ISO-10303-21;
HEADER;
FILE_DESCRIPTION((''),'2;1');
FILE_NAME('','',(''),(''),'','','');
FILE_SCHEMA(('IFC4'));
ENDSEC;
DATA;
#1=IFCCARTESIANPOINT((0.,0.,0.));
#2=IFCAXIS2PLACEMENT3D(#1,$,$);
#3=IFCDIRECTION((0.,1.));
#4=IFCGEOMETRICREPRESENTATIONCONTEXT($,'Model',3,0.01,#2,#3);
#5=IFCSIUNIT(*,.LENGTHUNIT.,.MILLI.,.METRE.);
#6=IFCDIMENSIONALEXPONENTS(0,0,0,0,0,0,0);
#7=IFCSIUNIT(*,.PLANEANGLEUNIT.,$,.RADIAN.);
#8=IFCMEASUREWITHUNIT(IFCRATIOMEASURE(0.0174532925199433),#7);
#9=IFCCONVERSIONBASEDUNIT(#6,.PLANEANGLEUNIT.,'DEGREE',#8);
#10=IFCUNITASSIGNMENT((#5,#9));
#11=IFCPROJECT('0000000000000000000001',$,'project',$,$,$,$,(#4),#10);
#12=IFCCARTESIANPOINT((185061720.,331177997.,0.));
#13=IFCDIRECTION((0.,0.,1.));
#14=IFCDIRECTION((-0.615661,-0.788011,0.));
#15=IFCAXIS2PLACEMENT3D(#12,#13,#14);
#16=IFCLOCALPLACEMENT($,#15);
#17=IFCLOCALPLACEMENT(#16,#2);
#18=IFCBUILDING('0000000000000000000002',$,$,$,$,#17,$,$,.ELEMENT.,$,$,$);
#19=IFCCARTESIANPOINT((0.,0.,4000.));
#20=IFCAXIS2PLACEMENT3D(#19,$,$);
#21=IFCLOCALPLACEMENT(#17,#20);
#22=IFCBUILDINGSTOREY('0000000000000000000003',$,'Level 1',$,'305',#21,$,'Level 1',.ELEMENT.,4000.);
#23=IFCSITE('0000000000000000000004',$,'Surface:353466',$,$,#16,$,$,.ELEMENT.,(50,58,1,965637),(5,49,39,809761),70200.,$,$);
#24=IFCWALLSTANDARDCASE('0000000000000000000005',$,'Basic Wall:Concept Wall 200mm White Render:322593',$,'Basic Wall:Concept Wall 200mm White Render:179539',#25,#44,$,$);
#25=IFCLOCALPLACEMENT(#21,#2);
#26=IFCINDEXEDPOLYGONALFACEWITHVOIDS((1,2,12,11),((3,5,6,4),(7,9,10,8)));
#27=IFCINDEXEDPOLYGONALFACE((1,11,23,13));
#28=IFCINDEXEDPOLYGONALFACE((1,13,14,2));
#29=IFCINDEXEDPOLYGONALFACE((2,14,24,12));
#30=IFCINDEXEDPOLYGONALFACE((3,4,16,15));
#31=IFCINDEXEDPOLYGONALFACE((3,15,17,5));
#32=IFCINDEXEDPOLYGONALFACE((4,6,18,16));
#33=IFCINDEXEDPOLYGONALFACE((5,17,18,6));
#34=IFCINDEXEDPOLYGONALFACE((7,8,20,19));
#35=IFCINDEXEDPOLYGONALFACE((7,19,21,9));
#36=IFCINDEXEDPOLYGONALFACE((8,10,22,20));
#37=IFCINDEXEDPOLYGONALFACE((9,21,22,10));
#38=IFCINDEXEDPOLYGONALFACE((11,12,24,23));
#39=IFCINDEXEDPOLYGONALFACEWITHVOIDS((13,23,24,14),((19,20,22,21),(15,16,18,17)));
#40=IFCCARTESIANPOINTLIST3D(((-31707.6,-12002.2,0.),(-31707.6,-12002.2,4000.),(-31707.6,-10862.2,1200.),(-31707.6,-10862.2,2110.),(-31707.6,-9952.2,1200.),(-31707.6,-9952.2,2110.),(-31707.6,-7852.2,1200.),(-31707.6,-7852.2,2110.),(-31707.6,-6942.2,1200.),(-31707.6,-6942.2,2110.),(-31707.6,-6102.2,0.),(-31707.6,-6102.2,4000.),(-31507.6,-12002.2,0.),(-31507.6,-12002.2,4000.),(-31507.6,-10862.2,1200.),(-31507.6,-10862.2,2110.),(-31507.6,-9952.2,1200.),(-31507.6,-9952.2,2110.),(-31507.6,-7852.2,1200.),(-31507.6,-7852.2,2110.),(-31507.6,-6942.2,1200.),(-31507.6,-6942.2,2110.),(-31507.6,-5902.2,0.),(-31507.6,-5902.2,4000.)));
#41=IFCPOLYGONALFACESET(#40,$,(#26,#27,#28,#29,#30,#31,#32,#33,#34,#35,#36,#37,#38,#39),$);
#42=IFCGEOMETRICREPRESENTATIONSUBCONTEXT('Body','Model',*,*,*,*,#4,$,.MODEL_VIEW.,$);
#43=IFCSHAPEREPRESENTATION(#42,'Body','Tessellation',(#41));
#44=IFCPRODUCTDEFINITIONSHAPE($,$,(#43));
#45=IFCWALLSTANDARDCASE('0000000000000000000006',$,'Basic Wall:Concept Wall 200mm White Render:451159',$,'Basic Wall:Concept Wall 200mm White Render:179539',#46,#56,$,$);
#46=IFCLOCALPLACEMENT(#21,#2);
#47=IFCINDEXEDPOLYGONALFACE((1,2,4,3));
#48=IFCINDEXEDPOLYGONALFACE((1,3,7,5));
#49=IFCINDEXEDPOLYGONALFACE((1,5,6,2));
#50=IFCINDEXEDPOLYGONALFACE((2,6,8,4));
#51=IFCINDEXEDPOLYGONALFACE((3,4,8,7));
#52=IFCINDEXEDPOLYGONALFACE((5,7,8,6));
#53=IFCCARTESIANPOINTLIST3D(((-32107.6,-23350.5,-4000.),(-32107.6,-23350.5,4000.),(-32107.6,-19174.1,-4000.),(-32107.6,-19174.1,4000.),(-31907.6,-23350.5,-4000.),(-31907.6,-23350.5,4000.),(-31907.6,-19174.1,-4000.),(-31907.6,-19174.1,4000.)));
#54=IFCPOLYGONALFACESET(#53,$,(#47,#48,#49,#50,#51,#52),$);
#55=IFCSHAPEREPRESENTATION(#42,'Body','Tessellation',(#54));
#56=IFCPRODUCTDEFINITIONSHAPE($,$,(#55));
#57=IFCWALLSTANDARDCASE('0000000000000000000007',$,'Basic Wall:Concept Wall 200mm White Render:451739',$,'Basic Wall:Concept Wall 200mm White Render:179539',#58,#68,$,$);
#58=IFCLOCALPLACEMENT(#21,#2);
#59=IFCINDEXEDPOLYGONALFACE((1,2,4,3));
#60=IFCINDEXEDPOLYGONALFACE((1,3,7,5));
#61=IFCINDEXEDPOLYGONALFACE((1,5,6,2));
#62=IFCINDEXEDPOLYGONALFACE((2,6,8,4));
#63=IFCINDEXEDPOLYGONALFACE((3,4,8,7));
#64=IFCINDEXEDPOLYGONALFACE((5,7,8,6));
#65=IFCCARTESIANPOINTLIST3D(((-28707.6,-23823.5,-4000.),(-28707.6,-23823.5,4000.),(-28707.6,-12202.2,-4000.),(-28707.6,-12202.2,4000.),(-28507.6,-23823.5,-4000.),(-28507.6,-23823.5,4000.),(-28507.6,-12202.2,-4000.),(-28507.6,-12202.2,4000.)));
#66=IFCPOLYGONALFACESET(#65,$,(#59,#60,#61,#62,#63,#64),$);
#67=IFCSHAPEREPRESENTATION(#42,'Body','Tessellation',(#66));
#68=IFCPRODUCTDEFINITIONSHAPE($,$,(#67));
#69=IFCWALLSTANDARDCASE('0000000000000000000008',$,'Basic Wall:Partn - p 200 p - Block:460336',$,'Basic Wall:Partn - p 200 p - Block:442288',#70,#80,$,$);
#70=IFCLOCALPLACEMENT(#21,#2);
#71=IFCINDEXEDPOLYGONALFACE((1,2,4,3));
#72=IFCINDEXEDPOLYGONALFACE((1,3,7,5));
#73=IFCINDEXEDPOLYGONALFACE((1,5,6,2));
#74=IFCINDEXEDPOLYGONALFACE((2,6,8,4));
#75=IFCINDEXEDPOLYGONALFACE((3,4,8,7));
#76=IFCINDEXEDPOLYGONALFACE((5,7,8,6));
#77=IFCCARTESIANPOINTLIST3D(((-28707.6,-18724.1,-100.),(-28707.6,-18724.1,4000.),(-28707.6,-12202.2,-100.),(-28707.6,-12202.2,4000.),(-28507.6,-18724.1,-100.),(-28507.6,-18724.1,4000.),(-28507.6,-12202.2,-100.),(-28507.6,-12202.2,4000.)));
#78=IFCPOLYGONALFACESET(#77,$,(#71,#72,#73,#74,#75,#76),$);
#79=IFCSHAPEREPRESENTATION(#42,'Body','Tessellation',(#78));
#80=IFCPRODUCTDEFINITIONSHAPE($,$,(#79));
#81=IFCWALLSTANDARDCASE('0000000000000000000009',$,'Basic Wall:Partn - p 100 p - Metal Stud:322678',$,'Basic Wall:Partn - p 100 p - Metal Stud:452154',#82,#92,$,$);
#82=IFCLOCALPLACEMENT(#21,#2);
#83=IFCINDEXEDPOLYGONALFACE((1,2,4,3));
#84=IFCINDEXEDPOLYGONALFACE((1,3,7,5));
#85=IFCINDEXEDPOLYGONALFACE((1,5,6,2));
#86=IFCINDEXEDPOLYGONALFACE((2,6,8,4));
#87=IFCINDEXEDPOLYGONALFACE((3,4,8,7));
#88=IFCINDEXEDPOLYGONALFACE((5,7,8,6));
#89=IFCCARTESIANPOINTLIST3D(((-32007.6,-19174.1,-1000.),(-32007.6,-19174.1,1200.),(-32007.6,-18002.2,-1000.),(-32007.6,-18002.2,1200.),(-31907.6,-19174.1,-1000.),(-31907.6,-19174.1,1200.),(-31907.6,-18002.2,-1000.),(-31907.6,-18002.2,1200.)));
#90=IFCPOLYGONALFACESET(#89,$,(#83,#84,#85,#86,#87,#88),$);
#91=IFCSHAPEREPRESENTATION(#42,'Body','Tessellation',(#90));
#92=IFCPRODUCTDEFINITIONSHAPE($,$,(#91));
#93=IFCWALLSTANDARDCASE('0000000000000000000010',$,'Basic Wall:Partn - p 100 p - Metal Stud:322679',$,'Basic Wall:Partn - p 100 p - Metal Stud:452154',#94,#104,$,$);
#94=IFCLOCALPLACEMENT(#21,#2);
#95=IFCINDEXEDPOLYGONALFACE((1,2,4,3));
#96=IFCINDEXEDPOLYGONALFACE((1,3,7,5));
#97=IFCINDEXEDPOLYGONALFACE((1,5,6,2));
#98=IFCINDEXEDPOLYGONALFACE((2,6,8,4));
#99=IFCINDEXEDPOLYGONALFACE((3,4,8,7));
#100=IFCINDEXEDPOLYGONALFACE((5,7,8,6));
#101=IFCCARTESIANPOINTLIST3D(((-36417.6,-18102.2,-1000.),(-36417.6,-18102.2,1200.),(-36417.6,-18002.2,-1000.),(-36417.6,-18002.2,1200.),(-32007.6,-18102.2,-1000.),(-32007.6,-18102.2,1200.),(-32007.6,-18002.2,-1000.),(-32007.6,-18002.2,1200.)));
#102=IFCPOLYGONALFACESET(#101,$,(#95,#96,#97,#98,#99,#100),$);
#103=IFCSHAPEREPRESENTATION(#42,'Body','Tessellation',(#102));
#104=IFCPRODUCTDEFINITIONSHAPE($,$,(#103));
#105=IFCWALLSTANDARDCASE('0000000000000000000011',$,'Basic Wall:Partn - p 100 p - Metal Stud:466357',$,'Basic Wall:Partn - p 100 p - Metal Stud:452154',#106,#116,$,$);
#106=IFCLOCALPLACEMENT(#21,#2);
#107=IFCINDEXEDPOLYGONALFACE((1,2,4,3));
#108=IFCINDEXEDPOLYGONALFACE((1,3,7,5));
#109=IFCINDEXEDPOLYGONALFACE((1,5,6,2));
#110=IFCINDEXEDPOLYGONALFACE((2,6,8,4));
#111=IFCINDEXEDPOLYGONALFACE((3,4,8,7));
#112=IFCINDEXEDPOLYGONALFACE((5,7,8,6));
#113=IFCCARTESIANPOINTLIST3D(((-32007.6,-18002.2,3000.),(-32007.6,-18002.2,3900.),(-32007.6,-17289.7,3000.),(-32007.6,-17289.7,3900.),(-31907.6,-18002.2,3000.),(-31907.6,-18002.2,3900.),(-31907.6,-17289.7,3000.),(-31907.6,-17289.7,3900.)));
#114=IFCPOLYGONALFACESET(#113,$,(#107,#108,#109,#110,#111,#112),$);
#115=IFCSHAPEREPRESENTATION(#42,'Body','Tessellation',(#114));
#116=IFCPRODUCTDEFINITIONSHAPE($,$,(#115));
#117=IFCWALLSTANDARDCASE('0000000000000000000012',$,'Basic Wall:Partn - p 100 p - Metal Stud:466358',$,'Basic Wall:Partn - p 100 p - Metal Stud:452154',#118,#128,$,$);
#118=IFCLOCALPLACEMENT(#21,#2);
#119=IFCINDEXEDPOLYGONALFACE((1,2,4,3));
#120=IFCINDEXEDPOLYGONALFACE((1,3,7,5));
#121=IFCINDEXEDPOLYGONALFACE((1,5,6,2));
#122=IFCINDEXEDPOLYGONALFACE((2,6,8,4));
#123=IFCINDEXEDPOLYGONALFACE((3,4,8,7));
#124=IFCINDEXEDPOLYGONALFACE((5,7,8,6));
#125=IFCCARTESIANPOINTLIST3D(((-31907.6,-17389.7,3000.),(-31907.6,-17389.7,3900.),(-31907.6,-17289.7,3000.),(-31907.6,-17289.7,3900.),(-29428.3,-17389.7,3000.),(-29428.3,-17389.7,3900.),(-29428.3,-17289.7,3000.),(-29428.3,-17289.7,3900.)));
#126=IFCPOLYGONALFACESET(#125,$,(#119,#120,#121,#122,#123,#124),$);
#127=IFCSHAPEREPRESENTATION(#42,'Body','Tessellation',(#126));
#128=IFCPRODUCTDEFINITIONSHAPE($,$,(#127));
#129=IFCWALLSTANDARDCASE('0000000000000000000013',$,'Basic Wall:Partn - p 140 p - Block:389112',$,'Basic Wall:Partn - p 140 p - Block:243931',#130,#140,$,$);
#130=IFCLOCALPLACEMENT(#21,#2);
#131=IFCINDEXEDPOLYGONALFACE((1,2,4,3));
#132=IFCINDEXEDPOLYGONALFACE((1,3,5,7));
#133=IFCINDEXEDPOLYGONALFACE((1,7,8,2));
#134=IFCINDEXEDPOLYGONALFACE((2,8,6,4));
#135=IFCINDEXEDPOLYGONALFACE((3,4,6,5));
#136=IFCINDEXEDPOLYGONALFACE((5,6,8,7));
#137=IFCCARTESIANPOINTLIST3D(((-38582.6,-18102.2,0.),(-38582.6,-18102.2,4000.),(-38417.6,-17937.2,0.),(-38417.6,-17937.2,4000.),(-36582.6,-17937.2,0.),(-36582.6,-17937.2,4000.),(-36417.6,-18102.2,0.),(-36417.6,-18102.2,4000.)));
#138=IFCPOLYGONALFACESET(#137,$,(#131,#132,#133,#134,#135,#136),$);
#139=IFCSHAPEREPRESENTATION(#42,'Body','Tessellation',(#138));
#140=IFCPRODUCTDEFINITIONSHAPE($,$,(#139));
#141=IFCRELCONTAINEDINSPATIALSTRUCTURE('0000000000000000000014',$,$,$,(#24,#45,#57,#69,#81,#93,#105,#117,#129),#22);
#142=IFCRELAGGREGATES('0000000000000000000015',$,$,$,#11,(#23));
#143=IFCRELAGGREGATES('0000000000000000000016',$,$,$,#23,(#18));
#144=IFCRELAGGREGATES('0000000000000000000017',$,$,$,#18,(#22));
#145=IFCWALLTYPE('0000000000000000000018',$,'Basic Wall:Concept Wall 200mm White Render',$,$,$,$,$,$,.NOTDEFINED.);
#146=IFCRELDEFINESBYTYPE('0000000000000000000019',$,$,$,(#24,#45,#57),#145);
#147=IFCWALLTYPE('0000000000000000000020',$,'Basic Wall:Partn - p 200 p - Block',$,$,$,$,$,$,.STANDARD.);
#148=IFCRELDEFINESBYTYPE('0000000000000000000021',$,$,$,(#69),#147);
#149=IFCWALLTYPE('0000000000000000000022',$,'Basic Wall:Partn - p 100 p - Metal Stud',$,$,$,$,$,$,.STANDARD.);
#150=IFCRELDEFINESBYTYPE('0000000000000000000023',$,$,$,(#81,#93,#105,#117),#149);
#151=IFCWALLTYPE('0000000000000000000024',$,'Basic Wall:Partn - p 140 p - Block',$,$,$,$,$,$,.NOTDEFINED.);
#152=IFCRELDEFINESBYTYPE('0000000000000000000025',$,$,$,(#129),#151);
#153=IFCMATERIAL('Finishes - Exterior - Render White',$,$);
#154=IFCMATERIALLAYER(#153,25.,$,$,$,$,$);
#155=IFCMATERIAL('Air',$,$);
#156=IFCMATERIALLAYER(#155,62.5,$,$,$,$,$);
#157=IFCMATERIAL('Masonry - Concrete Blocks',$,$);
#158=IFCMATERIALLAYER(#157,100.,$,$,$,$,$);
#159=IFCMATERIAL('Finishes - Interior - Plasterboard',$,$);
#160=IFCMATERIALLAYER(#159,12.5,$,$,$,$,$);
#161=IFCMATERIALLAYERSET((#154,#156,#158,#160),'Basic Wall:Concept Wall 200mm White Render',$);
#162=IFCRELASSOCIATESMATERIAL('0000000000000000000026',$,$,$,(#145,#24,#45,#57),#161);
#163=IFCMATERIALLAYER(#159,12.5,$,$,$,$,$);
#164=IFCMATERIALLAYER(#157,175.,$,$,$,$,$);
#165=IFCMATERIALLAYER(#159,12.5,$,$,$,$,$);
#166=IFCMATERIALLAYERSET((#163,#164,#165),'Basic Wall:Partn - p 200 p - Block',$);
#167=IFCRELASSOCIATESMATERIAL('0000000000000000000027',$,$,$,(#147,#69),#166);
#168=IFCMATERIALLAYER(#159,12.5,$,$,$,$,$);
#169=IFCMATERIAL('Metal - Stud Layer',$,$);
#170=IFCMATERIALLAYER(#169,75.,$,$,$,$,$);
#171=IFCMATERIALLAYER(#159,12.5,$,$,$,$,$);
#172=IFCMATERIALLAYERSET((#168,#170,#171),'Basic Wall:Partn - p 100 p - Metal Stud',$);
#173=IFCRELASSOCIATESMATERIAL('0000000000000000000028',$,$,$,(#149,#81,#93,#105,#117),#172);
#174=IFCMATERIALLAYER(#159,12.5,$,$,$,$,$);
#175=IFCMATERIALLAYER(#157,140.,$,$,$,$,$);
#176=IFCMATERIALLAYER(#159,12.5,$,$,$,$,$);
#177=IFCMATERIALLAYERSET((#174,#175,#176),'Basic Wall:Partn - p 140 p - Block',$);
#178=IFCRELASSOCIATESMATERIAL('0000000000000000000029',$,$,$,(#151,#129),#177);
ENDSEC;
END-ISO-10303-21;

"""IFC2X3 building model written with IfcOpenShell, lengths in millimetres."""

from ifc_helpers import new_model, entity, si_unit, converted_unit, direction, frame, frame_2d, origin, place, context, subcontext, project, spatial, polyline, rectangle, outline, extrude, clip, halfspace, material, layer, layer_set, layer_usage, type_object, element, save


model = new_model("IFC2X3")

# Units and contexts
model_context = context("Model", 3, precision=0.01, world=origin(), true_north=direction((0.0, 1.0)))
body_context = subcontext(model_context, "Body", "Model", "MODEL_VIEW")
ifc_project = project(units=[si_unit("LENGTHUNIT", "METRE", prefix="MILLI"), converted_unit("PLANEANGLEUNIT", "DEGREE", entity("IfcRatioMeasure", 0.0174532925199433), si_unit("PLANEANGLEUNIT", "RADIAN"), dimensions=[0, 0, 0, 0, 0, 0, 0])], contexts=[model_context])

# Site, building, storey
site_placement = place(None, frame((185061720.0, 331177997.0, 0.0), z_axis=(0.0, 0.0, 1.0), x_axis=(-0.615661, -0.788011, 0.0)))
site = spatial("IfcSite", under=ifc_project, at=site_placement, Name="Surface:353466", CompositionType="ELEMENT", RefLatitude=(50, 58, 1, 965637), RefLongitude=(5, 49, 39, 809761), RefElevation=70200.0)
building_placement = place(site_placement, origin())
building = spatial("IfcBuilding", under=site, at=building_placement, CompositionType="ELEMENT")
storey_placement = place(building_placement, frame((0.0, 0.0, 4000.0)))
storey = spatial("IfcBuildingStorey", under=building, at=storey_placement, Name="Level 1", ObjectType="305", LongName="Level 1", CompositionType="ELEMENT", Elevation=4000.0)

# Shared definitions
ifc_material_1 = material(Name="Masonry - Concrete Blocks")
ifc_material_2 = material(Name="Finishes - Interior - Plasterboard")

# Wall, openings
ifc_material_3 = material(Name="Finishes - Exterior - Render White")
ifc_layer_1 = layer(ifc_material_3, 25.0)
ifc_material_4 = material(Name="Air")
ifc_layer_2 = layer(ifc_material_4, 62.5)
ifc_layer_3 = layer(ifc_material_1, 100.0)
ifc_layer_4 = layer(ifc_material_2, 12.5)
ifc_layer_set_1 = layer_set([ifc_layer_1, ifc_layer_2, ifc_layer_3, ifc_layer_4], Name="Basic Wall:Concept Wall 200mm White Render")
ifc_layer_usage_1 = layer_usage(ifc_layer_set_1, "AXIS2", "POSITIVE", -100.0)
wall_type_1 = type_object("IfcWallType", Name="Basic Wall:Concept Wall 200mm White Render", PredefinedType="NOTDEFINED", material=ifc_layer_set_1)
wall_1_placement = place(storey_placement, frame((-31607.6, -12002.2, 0.0), z_axis=(0.0, 0.0, 1.0), x_axis=(0.0, 1.0, 0.0)))
wall_1 = element("IfcWallStandardCase", 1, at=wall_1_placement, inside=storey, type_object=wall_type_1, material=ifc_layer_usage_1, Name="Basic Wall:Concept Wall 200mm White Render:322593", ObjectType="Basic Wall:Concept Wall 200mm White Render:179539", context=body_context, shape_type="Clipping", body=[
    clip(extrude(outline(polyline([(6100.0, -100.0), (5900.0, 100.0), (0.0, 100.0), (0.0, -100.0), (6100.0, -100.0)])), origin(), (0.0, 0.0, 1.0), 4000.0), halfspace(frame((0.0, 0.0, -4000.0)), True)),
])
opening_1_placement = place(wall_1_placement, frame((1140.0, 1624.0, 1200.0)))
element("IfcOpeningElement", 2, at=opening_1_placement, cuts=wall_1, ObjectType="Opening", context=body_context, shape_type="SweptSolid", body=[
    extrude(rectangle(XDim=910.0, YDim=910.0, at=frame_2d((0.0, 0.0), x_axis=(1.0, 0.0))), frame((455.0, -3048.0, 455.0), z_axis=(0.0, 1.0, 0.0), x_axis=(0.0, 0.0, -1.0)), (0.0, 0.0, 1.0), 3048.0),
])
opening_2_placement = place(wall_1_placement, frame((4150.0, 1624.0, 1200.0)))
element("IfcOpeningElement", 3, at=opening_2_placement, cuts=wall_1, ObjectType="Opening", context=body_context, shape_type="SweptSolid", body=[
    extrude(rectangle(XDim=910.0, YDim=910.0, at=frame_2d((0.0, 0.0), x_axis=(1.0, 0.0))), frame((455.0, -3048.0, 455.0), z_axis=(0.0, 1.0, 0.0), x_axis=(0.0, 0.0, -1.0)), (0.0, 0.0, 1.0), 3048.0),
])
opening_3_placement = place(wall_1_placement, frame((2050.0, 100.0, 1200.0)))
element("IfcOpeningElement", 4, at=opening_3_placement, cuts=wall_1, ObjectType="Opening", context=body_context, shape_type="SweptSolid", body=[
    extrude(rectangle(XDim=910.0, YDim=910.0, at=frame_2d((455.0, 455.0), x_axis=(-1.0, 0.0))), frame((0.0, 0.0, 0.0), z_axis=(0.0, -1.0, 0.0), x_axis=(0.0, 0.0, 1.0)), (0.0, 0.0, 1.0), 200.0),
])
opening_4_placement = place(wall_1_placement, frame((5060.0, 100.0, 1200.0)))
element("IfcOpeningElement", 5, at=opening_4_placement, cuts=wall_1, ObjectType="Opening", context=body_context, shape_type="SweptSolid", body=[
    extrude(rectangle(XDim=910.0, YDim=910.0, at=frame_2d((455.0, 455.0), x_axis=(-1.0, 0.0))), frame((0.0, 0.0, 0.0), z_axis=(0.0, -1.0, 0.0), x_axis=(0.0, 0.0, 1.0)), (0.0, 0.0, 1.0), 200.0),
])

# Walls
ifc_layer_usage_2 = layer_usage(ifc_layer_set_1, "AXIS2", "POSITIVE", -100.0)
wall_2_placement = place(storey_placement, frame((-32007.6, -19174.1, -4000.0), z_axis=(0.0, 0.0, 1.0), x_axis=(0.0, -1.0, 0.0)))
element("IfcWallStandardCase", 6, at=wall_2_placement, inside=storey, type_object=wall_type_1, material=ifc_layer_usage_2, Name="Basic Wall:Concept Wall 200mm White Render:451159", ObjectType="Basic Wall:Concept Wall 200mm White Render:179539", context=body_context, shape_type="Clipping", body=[
    clip(extrude(rectangle(XDim=4176.4, YDim=200.0, at=frame_2d((2088.2, 0.0), x_axis=(-1.0, 0.0))), origin(), (0.0, 0.0, 1.0), 8000.0), halfspace(frame((0.0, 0.0, -4000.0)), True)),
])
ifc_layer_usage_3 = layer_usage(ifc_layer_set_1, "AXIS2", "POSITIVE", -100.0)
wall_3_placement = place(storey_placement, frame((-28607.6, -23823.5, -4000.0), z_axis=(0.0, 0.0, 1.0), x_axis=(0.0, 1.0, 0.0)))
element("IfcWallStandardCase", 7, at=wall_3_placement, inside=storey, type_object=wall_type_1, material=ifc_layer_usage_3, Name="Basic Wall:Concept Wall 200mm White Render:451739", ObjectType="Basic Wall:Concept Wall 200mm White Render:179539", context=body_context, shape_type="Clipping", body=[
    clip(extrude(rectangle(XDim=11621.2, YDim=200.0, at=frame_2d((5810.6, 0.0), x_axis=(-1.0, 0.0))), origin(), (0.0, 0.0, 1.0), 8000.0), halfspace(frame((0.0, 0.0, -4000.0)), True)),
])
ifc_layer_5 = layer(ifc_material_2, 12.5)
ifc_layer_6 = layer(ifc_material_1, 175.0)
ifc_layer_7 = layer(ifc_material_2, 12.5)
ifc_layer_set_2 = layer_set([ifc_layer_5, ifc_layer_6, ifc_layer_7], Name="Basic Wall:Partn - p 200 p - Block")
ifc_layer_usage_4 = layer_usage(ifc_layer_set_2, "AXIS2", "POSITIVE", -100.0)
wall_type_2 = type_object("IfcWallType", Name="Basic Wall:Partn - p 200 p - Block", PredefinedType="STANDARD", material=ifc_layer_set_2)
wall_4_placement = place(storey_placement, frame((-28607.6, -18724.1, -100.0), z_axis=(0.0, 0.0, 1.0), x_axis=(0.0, 1.0, 0.0)))
element("IfcWallStandardCase", 8, at=wall_4_placement, inside=storey, type_object=wall_type_2, material=ifc_layer_usage_4, Name="Basic Wall:Partn - p 200 p - Block:460336", ObjectType="Basic Wall:Partn - p 200 p - Block:442288", context=body_context, shape_type="Clipping", body=[
    clip(extrude(rectangle(XDim=6521.9, YDim=200.0, at=frame_2d((3261.0, 0.0), x_axis=(-1.0, 0.0))), origin(), (0.0, 0.0, 1.0), 4100.0), halfspace(frame((0.0, 0.0, -100.0)), True)),
])
ifc_layer_8 = layer(ifc_material_2, 12.5)
ifc_material_5 = material(Name="Metal - Stud Layer")
ifc_layer_9 = layer(ifc_material_5, 75.0)
ifc_layer_10 = layer(ifc_material_2, 12.5)
ifc_layer_set_3 = layer_set([ifc_layer_8, ifc_layer_9, ifc_layer_10], Name="Basic Wall:Partn - p 100 p - Metal Stud")
ifc_layer_usage_5 = layer_usage(ifc_layer_set_3, "AXIS2", "NEGATIVE", 50.0)
wall_type_3 = type_object("IfcWallType", Name="Basic Wall:Partn - p 100 p - Metal Stud", PredefinedType="STANDARD", material=ifc_layer_set_3)
wall_5_placement = place(storey_placement, frame((-31957.6, -19174.1, -1000.0), z_axis=(0.0, 0.0, 1.0), x_axis=(0.0, 1.0, 0.0)))
element("IfcWallStandardCase", 9, at=wall_5_placement, inside=storey, type_object=wall_type_3, material=ifc_layer_usage_5, Name="Basic Wall:Partn - p 100 p - Metal Stud:322678", ObjectType="Basic Wall:Partn - p 100 p - Metal Stud:452154", context=body_context, shape_type="SweptSolid", body=[
    extrude(rectangle(XDim=1171.9, YDim=100.0, at=frame_2d((586.0, 0.0), x_axis=(-1.0, 0.0))), origin(), (0.0, 0.0, 1.0), 2200.0),
])
ifc_layer_usage_6 = layer_usage(ifc_layer_set_3, "AXIS2", "NEGATIVE", 50.0)
wall_6_placement = place(storey_placement, frame((-32007.6, -18052.2, -1000.0), z_axis=(0.0, 0.0, 1.0), x_axis=(-1.0, 0.0, 0.0)))
element("IfcWallStandardCase", 10, at=wall_6_placement, inside=storey, type_object=wall_type_3, material=ifc_layer_usage_6, Name="Basic Wall:Partn - p 100 p - Metal Stud:322679", ObjectType="Basic Wall:Partn - p 100 p - Metal Stud:452154", context=body_context, shape_type="SweptSolid", body=[
    extrude(rectangle(XDim=4410.0, YDim=100.0, at=frame_2d((2205.0, 0.0), x_axis=(-1.0, 0.0))), origin(), (0.0, 0.0, 1.0), 2200.0),
])
ifc_layer_usage_7 = layer_usage(ifc_layer_set_3, "AXIS2", "NEGATIVE", 50.0)
wall_7_placement = place(storey_placement, frame((-31957.6, -17289.7, 3000.0), z_axis=(0.0, 0.0, 1.0), x_axis=(0.0, -1.0, 0.0)))
element("IfcWallStandardCase", 11, at=wall_7_placement, inside=storey, type_object=wall_type_3, material=ifc_layer_usage_7, Name="Basic Wall:Partn - p 100 p - Metal Stud:466357", ObjectType="Basic Wall:Partn - p 100 p - Metal Stud:452154", context=body_context, shape_type="SweptSolid", body=[
    extrude(rectangle(XDim=712.5, YDim=100.0, at=frame_2d((356.2, 0.0), x_axis=(-1.0, 0.0))), origin(), (0.0, 0.0, 1.0), 900.0),
])
ifc_layer_usage_8 = layer_usage(ifc_layer_set_3, "AXIS2", "NEGATIVE", 50.0)
wall_8_placement = place(storey_placement, frame((-29428.3, -17339.7, 3000.0), z_axis=(0.0, 0.0, 1.0), x_axis=(-1.0, 0.0, 0.0)))
element("IfcWallStandardCase", 12, at=wall_8_placement, inside=storey, type_object=wall_type_3, material=ifc_layer_usage_8, Name="Basic Wall:Partn - p 100 p - Metal Stud:466358", ObjectType="Basic Wall:Partn - p 100 p - Metal Stud:452154", context=body_context, shape_type="SweptSolid", body=[
    extrude(rectangle(XDim=2479.3, YDim=100.0, at=frame_2d((1239.6, 0.0), x_axis=(-1.0, 0.0))), origin(), (0.0, 0.0, 1.0), 900.0),
])
ifc_layer_11 = layer(ifc_material_2, 12.5)
ifc_layer_12 = layer(ifc_material_1, 140.0)
ifc_layer_13 = layer(ifc_material_2, 12.5)
ifc_layer_set_4 = layer_set([ifc_layer_11, ifc_layer_12, ifc_layer_13], Name="Basic Wall:Partn - p 140 p - Block")
ifc_layer_usage_9 = layer_usage(ifc_layer_set_4, "AXIS2", "NEGATIVE", 82.5)
wall_type_4 = type_object("IfcWallType", Name="Basic Wall:Partn - p 140 p - Block", PredefinedType="NOTDEFINED", material=ifc_layer_set_4)
wall_9_placement = place(storey_placement, frame((-36417.6, -18019.7, 0.0), z_axis=(0.0, 0.0, 1.0), x_axis=(-1.0, 0.0, 0.0)))
element("IfcWallStandardCase", 13, at=wall_9_placement, inside=storey, type_object=wall_type_4, material=ifc_layer_usage_9, Name="Basic Wall:Partn - p 140 p - Block:389112", ObjectType="Basic Wall:Partn - p 140 p - Block:243931", context=body_context, shape_type="Clipping", body=[
    clip(extrude(outline(polyline([(2000.0, -82.5), (2165.0, 82.5), (0.0, 82.5), (165.0, -82.5), (2000.0, -82.5)])), origin(), (0.0, 0.0, 1.0), 4000.0), halfspace(frame((0.0, 0.0, -4000.0)), True)),
])

save(model, "model.ifc")
